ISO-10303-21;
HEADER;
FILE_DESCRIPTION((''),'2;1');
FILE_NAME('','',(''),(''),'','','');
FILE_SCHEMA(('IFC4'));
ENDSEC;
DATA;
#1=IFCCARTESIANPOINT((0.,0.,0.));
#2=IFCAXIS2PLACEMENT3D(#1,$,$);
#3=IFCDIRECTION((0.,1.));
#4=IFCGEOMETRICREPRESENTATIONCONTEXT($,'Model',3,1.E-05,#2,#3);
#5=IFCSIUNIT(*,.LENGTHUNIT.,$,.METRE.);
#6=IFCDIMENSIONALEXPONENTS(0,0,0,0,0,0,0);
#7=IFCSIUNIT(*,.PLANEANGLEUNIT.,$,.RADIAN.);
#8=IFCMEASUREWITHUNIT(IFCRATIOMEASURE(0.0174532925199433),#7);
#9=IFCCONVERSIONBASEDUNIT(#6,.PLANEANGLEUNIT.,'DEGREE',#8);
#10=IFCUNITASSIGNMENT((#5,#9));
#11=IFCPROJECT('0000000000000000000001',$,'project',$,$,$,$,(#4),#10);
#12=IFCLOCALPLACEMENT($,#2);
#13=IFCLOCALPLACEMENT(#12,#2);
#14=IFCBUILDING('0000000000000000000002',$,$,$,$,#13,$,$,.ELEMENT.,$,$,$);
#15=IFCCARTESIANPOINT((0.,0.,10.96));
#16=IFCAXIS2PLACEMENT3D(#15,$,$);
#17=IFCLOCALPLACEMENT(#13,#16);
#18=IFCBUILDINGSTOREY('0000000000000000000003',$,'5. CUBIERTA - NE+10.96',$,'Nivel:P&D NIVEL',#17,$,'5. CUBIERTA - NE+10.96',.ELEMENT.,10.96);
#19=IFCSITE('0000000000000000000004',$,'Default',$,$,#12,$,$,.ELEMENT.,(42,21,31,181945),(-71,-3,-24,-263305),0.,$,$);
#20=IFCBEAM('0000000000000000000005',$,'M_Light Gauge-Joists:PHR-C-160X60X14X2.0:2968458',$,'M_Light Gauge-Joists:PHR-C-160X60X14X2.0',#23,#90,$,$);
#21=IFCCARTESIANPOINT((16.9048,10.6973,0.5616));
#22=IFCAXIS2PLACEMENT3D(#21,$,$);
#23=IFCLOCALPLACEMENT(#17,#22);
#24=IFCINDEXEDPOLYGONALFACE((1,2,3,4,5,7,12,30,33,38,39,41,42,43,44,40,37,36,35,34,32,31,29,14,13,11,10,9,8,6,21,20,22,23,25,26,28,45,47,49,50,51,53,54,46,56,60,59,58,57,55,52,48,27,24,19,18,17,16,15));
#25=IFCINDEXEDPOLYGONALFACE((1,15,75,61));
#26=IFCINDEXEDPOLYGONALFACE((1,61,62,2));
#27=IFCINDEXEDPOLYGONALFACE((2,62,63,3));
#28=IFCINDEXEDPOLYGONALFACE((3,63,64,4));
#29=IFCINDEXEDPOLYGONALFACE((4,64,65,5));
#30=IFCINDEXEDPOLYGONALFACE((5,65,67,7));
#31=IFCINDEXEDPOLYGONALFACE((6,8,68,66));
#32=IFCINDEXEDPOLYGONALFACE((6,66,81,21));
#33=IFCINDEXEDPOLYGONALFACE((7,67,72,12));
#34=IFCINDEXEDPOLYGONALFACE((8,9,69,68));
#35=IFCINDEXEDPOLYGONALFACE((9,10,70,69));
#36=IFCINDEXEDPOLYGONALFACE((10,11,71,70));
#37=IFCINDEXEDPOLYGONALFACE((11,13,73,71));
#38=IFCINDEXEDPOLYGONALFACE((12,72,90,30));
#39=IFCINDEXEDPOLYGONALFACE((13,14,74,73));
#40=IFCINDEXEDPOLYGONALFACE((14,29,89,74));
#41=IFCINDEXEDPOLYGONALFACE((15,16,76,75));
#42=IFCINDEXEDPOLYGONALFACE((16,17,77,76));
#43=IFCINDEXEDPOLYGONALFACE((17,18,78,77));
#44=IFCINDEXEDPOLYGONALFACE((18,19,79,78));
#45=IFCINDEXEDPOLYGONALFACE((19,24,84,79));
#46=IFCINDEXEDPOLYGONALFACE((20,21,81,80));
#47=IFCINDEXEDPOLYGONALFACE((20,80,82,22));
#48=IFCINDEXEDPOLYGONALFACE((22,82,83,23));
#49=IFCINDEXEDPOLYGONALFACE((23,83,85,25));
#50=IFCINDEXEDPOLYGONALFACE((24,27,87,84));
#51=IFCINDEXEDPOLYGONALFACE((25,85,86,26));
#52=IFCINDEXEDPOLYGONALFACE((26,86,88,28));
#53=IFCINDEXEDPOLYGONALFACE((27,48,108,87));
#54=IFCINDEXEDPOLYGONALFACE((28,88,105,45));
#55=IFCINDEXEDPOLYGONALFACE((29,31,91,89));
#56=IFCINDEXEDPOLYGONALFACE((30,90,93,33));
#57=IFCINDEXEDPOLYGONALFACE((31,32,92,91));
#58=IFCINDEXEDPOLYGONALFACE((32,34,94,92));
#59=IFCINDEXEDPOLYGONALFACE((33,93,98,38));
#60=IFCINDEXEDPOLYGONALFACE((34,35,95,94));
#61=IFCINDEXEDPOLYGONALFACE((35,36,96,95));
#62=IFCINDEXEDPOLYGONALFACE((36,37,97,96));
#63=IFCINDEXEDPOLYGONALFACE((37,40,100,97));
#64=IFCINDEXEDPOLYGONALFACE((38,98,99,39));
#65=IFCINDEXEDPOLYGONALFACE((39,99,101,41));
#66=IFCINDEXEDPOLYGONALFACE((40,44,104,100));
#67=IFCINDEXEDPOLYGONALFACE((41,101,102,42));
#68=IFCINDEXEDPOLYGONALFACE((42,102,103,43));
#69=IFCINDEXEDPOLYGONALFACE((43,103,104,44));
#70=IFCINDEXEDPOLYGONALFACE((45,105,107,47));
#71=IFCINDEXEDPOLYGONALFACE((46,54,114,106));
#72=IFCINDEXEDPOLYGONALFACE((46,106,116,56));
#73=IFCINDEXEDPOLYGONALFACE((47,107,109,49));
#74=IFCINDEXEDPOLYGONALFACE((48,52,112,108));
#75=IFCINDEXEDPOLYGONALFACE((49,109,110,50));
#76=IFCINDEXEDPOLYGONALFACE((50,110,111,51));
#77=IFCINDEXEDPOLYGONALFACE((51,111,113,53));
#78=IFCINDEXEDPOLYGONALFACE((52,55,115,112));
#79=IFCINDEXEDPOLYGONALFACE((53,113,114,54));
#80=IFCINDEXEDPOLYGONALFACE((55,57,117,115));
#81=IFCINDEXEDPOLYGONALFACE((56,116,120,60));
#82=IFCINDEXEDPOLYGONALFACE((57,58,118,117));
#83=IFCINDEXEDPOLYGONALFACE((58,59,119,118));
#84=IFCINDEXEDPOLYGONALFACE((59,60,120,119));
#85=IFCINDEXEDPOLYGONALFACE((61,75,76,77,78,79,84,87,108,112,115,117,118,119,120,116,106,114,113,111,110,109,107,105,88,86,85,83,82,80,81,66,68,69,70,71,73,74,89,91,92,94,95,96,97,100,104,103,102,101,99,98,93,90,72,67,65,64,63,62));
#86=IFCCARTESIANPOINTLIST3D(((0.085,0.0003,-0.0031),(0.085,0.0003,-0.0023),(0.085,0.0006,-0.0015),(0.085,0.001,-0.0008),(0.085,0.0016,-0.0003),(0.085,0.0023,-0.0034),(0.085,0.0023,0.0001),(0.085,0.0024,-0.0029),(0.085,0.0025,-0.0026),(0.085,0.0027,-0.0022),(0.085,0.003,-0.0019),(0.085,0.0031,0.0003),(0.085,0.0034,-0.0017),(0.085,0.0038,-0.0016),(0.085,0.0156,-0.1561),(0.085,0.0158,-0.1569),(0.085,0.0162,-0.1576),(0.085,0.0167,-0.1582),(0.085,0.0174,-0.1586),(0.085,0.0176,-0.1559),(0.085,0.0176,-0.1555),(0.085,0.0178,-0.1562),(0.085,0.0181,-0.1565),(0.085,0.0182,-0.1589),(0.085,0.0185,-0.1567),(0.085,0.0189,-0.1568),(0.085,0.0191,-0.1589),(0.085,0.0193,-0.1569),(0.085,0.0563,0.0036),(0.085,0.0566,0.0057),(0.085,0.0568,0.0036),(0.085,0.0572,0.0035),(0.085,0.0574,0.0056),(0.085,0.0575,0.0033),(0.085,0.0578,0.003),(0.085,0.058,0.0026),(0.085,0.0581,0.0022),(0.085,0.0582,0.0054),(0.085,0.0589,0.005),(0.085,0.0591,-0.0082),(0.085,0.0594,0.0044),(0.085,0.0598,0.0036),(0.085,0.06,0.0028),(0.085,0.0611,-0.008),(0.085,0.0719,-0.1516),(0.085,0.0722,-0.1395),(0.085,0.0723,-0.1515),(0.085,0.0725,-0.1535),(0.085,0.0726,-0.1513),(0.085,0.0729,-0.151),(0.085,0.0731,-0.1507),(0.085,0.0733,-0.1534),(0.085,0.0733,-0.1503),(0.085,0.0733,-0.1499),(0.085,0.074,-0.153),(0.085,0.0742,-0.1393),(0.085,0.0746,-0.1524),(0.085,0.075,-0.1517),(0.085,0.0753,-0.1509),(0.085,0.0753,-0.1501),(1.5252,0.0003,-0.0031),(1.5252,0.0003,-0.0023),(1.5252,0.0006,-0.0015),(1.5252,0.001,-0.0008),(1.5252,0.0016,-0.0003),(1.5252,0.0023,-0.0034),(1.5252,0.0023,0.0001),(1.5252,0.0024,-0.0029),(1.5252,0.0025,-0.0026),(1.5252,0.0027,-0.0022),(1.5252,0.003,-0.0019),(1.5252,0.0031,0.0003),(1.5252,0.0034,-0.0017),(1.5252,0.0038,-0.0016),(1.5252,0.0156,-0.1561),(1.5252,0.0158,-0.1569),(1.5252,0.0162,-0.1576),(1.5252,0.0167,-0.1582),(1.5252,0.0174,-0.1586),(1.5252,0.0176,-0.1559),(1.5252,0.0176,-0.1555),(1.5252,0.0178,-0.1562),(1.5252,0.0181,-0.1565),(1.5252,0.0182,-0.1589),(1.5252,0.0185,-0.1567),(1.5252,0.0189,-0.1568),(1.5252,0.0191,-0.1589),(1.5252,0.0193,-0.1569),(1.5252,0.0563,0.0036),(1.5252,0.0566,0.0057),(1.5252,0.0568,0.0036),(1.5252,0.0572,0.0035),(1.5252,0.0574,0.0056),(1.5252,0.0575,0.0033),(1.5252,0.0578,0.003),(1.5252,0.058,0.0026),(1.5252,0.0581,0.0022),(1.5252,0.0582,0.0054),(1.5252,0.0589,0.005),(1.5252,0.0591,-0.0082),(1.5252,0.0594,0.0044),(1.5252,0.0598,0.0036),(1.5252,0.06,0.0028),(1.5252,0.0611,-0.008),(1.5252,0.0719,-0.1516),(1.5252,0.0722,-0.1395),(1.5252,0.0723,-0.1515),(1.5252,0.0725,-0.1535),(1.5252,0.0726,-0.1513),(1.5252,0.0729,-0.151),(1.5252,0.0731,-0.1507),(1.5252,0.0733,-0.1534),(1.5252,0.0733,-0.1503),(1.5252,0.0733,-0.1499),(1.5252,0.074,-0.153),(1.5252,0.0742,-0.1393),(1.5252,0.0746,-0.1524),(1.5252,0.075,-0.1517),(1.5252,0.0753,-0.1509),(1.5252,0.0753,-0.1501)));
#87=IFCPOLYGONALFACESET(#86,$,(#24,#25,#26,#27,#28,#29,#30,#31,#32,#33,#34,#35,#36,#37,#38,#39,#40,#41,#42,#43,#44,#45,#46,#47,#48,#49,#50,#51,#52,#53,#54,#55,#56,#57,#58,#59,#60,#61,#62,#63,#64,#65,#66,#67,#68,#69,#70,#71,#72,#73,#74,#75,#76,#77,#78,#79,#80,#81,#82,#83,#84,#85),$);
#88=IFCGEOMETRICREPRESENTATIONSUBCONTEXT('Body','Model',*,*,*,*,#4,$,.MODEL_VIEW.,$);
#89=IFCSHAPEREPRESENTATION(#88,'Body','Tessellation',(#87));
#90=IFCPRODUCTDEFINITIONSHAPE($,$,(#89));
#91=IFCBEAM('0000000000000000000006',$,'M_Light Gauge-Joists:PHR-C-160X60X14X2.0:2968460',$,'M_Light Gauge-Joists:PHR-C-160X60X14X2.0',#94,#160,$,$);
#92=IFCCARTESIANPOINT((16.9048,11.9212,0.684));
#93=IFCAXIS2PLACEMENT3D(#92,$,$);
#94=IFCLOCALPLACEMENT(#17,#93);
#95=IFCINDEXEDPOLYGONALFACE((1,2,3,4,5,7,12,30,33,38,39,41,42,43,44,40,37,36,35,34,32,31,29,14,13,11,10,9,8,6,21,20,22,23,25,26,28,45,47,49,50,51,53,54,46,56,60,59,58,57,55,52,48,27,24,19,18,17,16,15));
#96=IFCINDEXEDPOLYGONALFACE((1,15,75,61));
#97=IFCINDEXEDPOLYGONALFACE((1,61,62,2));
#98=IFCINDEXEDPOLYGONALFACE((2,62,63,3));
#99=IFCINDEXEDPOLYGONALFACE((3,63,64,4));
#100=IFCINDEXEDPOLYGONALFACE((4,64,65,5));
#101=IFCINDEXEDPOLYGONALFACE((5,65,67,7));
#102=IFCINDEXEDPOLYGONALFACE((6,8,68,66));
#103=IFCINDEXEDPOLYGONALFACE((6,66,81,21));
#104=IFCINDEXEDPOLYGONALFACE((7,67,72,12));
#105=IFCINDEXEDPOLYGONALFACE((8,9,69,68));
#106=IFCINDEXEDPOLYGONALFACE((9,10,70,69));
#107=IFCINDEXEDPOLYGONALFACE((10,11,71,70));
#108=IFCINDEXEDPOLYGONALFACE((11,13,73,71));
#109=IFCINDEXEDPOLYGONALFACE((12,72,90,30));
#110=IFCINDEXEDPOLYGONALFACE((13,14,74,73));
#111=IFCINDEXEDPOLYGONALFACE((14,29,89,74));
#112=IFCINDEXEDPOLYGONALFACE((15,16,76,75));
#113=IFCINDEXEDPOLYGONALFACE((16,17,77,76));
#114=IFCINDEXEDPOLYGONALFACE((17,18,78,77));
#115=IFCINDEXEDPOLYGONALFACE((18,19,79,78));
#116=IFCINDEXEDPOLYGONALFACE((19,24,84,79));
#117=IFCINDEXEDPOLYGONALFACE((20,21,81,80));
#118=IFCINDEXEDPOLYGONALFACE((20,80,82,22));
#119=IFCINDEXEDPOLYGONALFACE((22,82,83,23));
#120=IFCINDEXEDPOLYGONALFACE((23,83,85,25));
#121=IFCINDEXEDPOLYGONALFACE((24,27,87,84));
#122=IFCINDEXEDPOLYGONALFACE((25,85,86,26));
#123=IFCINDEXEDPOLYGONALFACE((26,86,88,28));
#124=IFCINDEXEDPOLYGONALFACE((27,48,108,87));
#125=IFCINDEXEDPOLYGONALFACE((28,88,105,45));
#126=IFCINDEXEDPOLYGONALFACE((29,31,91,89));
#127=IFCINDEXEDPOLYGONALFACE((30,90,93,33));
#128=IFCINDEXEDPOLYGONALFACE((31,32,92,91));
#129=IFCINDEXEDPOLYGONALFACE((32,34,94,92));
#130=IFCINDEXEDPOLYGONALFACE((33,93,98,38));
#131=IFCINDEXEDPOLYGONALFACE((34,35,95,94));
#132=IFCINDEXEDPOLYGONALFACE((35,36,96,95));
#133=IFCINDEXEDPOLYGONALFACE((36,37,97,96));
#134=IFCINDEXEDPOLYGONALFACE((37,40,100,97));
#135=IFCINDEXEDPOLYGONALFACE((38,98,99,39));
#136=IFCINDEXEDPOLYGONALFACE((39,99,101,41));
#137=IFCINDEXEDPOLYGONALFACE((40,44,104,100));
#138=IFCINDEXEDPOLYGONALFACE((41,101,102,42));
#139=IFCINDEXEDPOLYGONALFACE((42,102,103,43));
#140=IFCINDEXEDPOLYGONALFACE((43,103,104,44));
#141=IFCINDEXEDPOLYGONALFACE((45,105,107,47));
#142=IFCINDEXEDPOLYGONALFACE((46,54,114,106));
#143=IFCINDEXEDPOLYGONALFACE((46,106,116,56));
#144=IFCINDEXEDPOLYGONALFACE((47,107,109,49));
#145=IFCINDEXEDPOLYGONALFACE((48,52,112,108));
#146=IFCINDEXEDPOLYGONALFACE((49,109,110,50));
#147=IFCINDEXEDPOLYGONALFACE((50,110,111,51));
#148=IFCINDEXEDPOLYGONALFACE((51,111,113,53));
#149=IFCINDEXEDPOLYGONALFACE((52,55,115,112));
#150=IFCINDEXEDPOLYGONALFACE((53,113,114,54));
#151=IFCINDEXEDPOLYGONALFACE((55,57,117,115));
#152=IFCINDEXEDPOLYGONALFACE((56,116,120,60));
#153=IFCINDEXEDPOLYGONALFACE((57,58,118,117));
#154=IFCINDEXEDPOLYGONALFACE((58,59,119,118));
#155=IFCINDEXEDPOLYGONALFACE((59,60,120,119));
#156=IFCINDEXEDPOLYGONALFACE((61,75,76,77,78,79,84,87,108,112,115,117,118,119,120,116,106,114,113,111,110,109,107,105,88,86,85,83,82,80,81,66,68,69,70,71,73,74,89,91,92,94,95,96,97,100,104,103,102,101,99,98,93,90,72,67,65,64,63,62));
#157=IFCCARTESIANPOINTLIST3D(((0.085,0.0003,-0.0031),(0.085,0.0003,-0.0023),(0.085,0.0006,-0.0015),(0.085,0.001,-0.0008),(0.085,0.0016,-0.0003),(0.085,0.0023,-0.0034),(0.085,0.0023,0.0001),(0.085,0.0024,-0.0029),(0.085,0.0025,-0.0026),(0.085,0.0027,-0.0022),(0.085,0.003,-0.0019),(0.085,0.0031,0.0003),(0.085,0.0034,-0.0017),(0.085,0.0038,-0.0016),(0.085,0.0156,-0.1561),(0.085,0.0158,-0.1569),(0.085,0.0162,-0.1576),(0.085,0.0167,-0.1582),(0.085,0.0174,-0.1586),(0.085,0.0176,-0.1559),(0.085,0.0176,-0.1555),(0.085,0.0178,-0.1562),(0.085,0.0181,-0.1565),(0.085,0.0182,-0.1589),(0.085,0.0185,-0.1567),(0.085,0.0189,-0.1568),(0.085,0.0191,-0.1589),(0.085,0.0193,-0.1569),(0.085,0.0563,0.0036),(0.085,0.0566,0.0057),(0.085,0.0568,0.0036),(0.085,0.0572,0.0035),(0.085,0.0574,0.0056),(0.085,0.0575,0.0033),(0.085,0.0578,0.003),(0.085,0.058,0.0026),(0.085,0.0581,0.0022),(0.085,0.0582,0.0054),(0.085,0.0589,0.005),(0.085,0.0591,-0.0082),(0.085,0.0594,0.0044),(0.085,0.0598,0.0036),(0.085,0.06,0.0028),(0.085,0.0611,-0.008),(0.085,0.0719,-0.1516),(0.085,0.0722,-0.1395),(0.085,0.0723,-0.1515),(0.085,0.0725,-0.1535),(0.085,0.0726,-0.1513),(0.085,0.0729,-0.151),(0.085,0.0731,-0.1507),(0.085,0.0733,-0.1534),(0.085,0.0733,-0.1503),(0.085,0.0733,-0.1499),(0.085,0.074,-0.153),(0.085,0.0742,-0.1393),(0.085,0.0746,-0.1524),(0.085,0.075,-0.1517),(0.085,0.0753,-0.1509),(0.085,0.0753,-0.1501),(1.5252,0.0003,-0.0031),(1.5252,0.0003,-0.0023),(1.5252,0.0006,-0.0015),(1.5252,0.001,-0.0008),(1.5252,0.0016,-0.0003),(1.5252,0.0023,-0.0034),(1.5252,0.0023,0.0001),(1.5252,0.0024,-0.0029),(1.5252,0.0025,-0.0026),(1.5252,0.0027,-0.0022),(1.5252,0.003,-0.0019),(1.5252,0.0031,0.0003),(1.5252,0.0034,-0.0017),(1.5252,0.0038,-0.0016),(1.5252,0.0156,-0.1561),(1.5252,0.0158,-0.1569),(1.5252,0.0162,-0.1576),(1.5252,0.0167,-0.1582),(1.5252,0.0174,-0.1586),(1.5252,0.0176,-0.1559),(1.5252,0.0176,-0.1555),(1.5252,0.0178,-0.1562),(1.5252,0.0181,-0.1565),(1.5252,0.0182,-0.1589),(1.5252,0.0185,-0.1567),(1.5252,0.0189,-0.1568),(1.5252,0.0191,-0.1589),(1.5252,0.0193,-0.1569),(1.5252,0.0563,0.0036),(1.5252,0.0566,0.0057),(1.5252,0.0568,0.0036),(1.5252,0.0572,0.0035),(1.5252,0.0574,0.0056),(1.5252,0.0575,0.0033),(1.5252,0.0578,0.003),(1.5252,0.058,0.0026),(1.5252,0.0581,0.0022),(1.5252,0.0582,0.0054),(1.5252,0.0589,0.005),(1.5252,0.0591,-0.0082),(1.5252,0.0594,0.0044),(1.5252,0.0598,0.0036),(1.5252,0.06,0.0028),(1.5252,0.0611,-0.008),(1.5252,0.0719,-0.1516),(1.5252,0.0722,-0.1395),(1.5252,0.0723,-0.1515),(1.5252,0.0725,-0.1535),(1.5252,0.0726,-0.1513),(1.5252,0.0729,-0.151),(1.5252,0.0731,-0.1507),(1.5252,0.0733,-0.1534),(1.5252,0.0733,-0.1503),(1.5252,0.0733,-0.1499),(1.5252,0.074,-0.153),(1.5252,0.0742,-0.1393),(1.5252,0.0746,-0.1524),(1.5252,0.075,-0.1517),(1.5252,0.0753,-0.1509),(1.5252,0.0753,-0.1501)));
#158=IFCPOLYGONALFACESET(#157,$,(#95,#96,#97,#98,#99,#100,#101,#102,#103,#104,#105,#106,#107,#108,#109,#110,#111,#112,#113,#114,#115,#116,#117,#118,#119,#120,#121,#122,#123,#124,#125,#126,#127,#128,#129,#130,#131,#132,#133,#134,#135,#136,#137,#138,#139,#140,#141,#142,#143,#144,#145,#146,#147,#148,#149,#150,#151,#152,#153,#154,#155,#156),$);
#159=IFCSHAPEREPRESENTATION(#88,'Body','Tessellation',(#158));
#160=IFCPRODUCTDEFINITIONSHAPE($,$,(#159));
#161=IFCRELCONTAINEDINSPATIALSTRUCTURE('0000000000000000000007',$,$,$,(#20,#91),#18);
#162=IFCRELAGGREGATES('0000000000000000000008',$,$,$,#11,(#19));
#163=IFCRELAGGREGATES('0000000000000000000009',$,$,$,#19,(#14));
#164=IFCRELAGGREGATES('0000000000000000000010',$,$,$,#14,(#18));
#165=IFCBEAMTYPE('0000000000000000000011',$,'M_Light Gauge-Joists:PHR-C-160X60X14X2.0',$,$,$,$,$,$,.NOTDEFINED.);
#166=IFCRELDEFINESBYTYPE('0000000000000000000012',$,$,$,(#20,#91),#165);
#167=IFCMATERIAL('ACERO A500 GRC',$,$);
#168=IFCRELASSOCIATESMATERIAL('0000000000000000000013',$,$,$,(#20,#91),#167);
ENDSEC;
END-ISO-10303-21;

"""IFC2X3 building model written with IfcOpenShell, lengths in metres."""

from ifc_helpers import new_model, entity, si_unit, converted_unit, direction, frame, frame_2d, origin, place, context, subcontext, project, spatial, polyline, circle_curve, parameter, trimmed, segment, composite_curve, outline, extrude, material, type_object, element, save


model = new_model("IFC2X3")

# Units and contexts
model_context = context("Model", 3, precision=1e-05, world=origin(), true_north=direction((0.0, 1.0)))
body_context = subcontext(model_context, "Body", "Model", "MODEL_VIEW")
ifc_project = project(units=[si_unit("LENGTHUNIT", "METRE"), converted_unit("PLANEANGLEUNIT", "DEGREE", entity("IfcRatioMeasure", 0.0174532925199433), si_unit("PLANEANGLEUNIT", "RADIAN"), dimensions=[0, 0, 0, 0, 0, 0, 0])], contexts=[model_context])

# Site, building, storey
site_placement = place(None, origin())
site = spatial("IfcSite", under=ifc_project, at=site_placement, Name="Default", CompositionType="ELEMENT", RefLatitude=(42, 21, 31, 181945), RefLongitude=(-71, -3, -24, -263305), RefElevation=0.0)
building_placement = place(site_placement, origin())
building = spatial("IfcBuilding", under=site, at=building_placement, CompositionType="ELEMENT")
storey_placement = place(building_placement, frame((0.0, 0.0, 10.96)))
storey = spatial("IfcBuildingStorey", under=building, at=storey_placement, Name="5. CUBIERTA - NE+10.96", ObjectType="Nivel:P&D NIVEL", LongName="5. CUBIERTA - NE+10.96", CompositionType="ELEMENT", Elevation=10.96)

# Beams
ifc_material_1 = material(Name="ACERO A500 GRC")
beam_type_1 = type_object("IfcBeamType", Name="M_Light Gauge-Joists:PHR-C-160X60X14X2.0", PredefinedType="NOTDEFINED")
beam_1_placement = place(storey_placement, frame((16.9048, 10.6973, 0.5616)))
element("IfcBeam", 1, at=beam_1_placement, inside=storey, type_object=beam_type_1, material=ifc_material_1, Name="M_Light Gauge-Joists:PHR-C-160X60X14X2.0:2968458", ObjectType="M_Light Gauge-Joists:PHR-C-160X60X14X2.0", context=body_context, shape_type="SweptSolid", body=[
    extrude(outline(composite_curve([segment(trimmed(circle_curve(frame_2d((-0.0764, -0.0322), x_axis=(-1.0, 0.0)), 0.0016), [parameter(0.0)], [parameter(90.0)], True, "PARAMETER"), False, "CONTINUOUS"), segment(polyline([(-0.078, -0.0322), (-0.078, 0.0206)]), True, "CONTINUOUS"), segment(trimmed(circle_curve(frame_2d((-0.0764, 0.0206), x_axis=(0.0, 1.0)), 0.0016), [parameter(0.0)], [parameter(90.0)], True, "PARAMETER"), False, "CONTINUOUS"), segment(polyline([(-0.0764, 0.0222), (-0.066, 0.0222)]), True, "CONTINUOUS"), segment(polyline([(-0.066, 0.0222), (-0.066, 0.0242)]), True, "CONTINUOUS"), segment(polyline([(-0.066, 0.0242), (-0.0768, 0.0242)]), True, "CONTINUOUS"), segment(trimmed(circle_curve(frame_2d((-0.0768, 0.021), x_axis=(-1.0, 0.0)), 0.0032), [parameter(270.0)], [parameter(0.0)], True, "PARAMETER"), True, "CONTINUOUS"), segment(polyline([(-0.08, 0.021), (-0.08, -0.0326)]), True, "CONTINUOUS"), segment(trimmed(circle_curve(frame_2d((-0.0768, -0.0326), x_axis=(0.0, -1.0)), 0.0032), [parameter(270.0)], [parameter(0.0)], True, "PARAMETER"), True, "CONTINUOUS"), segment(polyline([(-0.0768, -0.0358), (0.0768, -0.0358)]), True, "CONTINUOUS"), segment(trimmed(circle_curve(frame_2d((0.0768, -0.0326), x_axis=(1.0, 0.0)), 0.0032), [parameter(270.0)], [parameter(0.0)], True, "PARAMETER"), True, "CONTINUOUS"), segment(polyline([(0.08, -0.0326), (0.08, 0.021)]), True, "CONTINUOUS"), segment(trimmed(circle_curve(frame_2d((0.0768, 0.021), x_axis=(0.0, 1.0)), 0.0032), [parameter(270.0)], [parameter(0.0)], True, "PARAMETER"), True, "CONTINUOUS"), segment(polyline([(0.0768, 0.0242), (0.066, 0.0242)]), True, "CONTINUOUS"), segment(polyline([(0.066, 0.0242), (0.066, 0.0222)]), True, "CONTINUOUS"), segment(polyline([(0.066, 0.0222), (0.0764, 0.0222)]), True, "CONTINUOUS"), segment(trimmed(circle_curve(frame_2d((0.0764, 0.0206), x_axis=(1.0, 0.0)), 0.0016), [parameter(0.0)], [parameter(90.0)], True, "PARAMETER"), False, "CONTINUOUS"), segment(polyline([(0.078, 0.0206), (0.078, -0.0322)]), True, "CONTINUOUS"), segment(trimmed(circle_curve(frame_2d((0.0764, -0.0322), x_axis=(0.0, -1.0)), 0.0016), [parameter(0.0)], [parameter(90.0)], True, "PARAMETER"), False, "CONTINUOUS"), segment(polyline([(0.0764, -0.0338), (-0.0764, -0.0338)]), True, "CONTINUOUS")], self_intersect=False)), frame((0.085, 0.0436, -0.076), z_axis=(-1.0, 0.0, 0.0), x_axis=(0.0, -0.099504, 0.995037)), (0.0, 0.0, -1.0), 1.4402),
])
beam_2_placement = place(storey_placement, frame((16.9048, 11.9212, 0.684)))
element("IfcBeam", 2, at=beam_2_placement, inside=storey, type_object=beam_type_1, material=ifc_material_1, Name="M_Light Gauge-Joists:PHR-C-160X60X14X2.0:2968460", ObjectType="M_Light Gauge-Joists:PHR-C-160X60X14X2.0", context=body_context, shape_type="SweptSolid", body=[
    extrude(outline(composite_curve([segment(trimmed(circle_curve(frame_2d((-0.0764, -0.0322), x_axis=(-1.0, 0.0)), 0.0016), [parameter(0.0)], [parameter(90.0)], True, "PARAMETER"), False, "CONTINUOUS"), segment(polyline([(-0.078, -0.0322), (-0.078, 0.0206)]), True, "CONTINUOUS"), segment(trimmed(circle_curve(frame_2d((-0.0764, 0.0206), x_axis=(0.0, 1.0)), 0.0016), [parameter(0.0)], [parameter(90.0)], True, "PARAMETER"), False, "CONTINUOUS"), segment(polyline([(-0.0764, 0.0222), (-0.066, 0.0222)]), True, "CONTINUOUS"), segment(polyline([(-0.066, 0.0222), (-0.066, 0.0242)]), True, "CONTINUOUS"), segment(polyline([(-0.066, 0.0242), (-0.0768, 0.0242)]), True, "CONTINUOUS"), segment(trimmed(circle_curve(frame_2d((-0.0768, 0.021), x_axis=(-1.0, 0.0)), 0.0032), [parameter(270.0)], [parameter(0.0)], True, "PARAMETER"), True, "CONTINUOUS"), segment(polyline([(-0.08, 0.021), (-0.08, -0.0326)]), True, "CONTINUOUS"), segment(trimmed(circle_curve(frame_2d((-0.0768, -0.0326), x_axis=(0.0, -1.0)), 0.0032), [parameter(270.0)], [parameter(0.0)], True, "PARAMETER"), True, "CONTINUOUS"), segment(polyline([(-0.0768, -0.0358), (0.0768, -0.0358)]), True, "CONTINUOUS"), segment(trimmed(circle_curve(frame_2d((0.0768, -0.0326), x_axis=(1.0, 0.0)), 0.0032), [parameter(270.0)], [parameter(0.0)], True, "PARAMETER"), True, "CONTINUOUS"), segment(polyline([(0.08, -0.0326), (0.08, 0.021)]), True, "CONTINUOUS"), segment(trimmed(circle_curve(frame_2d((0.0768, 0.021), x_axis=(0.0, 1.0)), 0.0032), [parameter(270.0)], [parameter(0.0)], True, "PARAMETER"), True, "CONTINUOUS"), segment(polyline([(0.0768, 0.0242), (0.066, 0.0242)]), True, "CONTINUOUS"), segment(polyline([(0.066, 0.0242), (0.066, 0.0222)]), True, "CONTINUOUS"), segment(polyline([(0.066, 0.0222), (0.0764, 0.0222)]), True, "CONTINUOUS"), segment(trimmed(circle_curve(frame_2d((0.0764, 0.0206), x_axis=(1.0, 0.0)), 0.0016), [parameter(0.0)], [parameter(90.0)], True, "PARAMETER"), False, "CONTINUOUS"), segment(polyline([(0.078, 0.0206), (0.078, -0.0322)]), True, "CONTINUOUS"), segment(trimmed(circle_curve(frame_2d((0.0764, -0.0322), x_axis=(0.0, -1.0)), 0.0016), [parameter(0.0)], [parameter(90.0)], True, "PARAMETER"), False, "CONTINUOUS"), segment(polyline([(0.0764, -0.0338), (-0.0764, -0.0338)]), True, "CONTINUOUS")], self_intersect=False)), frame((0.085, 0.0436, -0.076), z_axis=(-1.0, 0.0, 0.0), x_axis=(0.0, -0.099504, 0.995037)), (0.0, 0.0, -1.0), 1.4402),
])

save(model, "model.ifc")
